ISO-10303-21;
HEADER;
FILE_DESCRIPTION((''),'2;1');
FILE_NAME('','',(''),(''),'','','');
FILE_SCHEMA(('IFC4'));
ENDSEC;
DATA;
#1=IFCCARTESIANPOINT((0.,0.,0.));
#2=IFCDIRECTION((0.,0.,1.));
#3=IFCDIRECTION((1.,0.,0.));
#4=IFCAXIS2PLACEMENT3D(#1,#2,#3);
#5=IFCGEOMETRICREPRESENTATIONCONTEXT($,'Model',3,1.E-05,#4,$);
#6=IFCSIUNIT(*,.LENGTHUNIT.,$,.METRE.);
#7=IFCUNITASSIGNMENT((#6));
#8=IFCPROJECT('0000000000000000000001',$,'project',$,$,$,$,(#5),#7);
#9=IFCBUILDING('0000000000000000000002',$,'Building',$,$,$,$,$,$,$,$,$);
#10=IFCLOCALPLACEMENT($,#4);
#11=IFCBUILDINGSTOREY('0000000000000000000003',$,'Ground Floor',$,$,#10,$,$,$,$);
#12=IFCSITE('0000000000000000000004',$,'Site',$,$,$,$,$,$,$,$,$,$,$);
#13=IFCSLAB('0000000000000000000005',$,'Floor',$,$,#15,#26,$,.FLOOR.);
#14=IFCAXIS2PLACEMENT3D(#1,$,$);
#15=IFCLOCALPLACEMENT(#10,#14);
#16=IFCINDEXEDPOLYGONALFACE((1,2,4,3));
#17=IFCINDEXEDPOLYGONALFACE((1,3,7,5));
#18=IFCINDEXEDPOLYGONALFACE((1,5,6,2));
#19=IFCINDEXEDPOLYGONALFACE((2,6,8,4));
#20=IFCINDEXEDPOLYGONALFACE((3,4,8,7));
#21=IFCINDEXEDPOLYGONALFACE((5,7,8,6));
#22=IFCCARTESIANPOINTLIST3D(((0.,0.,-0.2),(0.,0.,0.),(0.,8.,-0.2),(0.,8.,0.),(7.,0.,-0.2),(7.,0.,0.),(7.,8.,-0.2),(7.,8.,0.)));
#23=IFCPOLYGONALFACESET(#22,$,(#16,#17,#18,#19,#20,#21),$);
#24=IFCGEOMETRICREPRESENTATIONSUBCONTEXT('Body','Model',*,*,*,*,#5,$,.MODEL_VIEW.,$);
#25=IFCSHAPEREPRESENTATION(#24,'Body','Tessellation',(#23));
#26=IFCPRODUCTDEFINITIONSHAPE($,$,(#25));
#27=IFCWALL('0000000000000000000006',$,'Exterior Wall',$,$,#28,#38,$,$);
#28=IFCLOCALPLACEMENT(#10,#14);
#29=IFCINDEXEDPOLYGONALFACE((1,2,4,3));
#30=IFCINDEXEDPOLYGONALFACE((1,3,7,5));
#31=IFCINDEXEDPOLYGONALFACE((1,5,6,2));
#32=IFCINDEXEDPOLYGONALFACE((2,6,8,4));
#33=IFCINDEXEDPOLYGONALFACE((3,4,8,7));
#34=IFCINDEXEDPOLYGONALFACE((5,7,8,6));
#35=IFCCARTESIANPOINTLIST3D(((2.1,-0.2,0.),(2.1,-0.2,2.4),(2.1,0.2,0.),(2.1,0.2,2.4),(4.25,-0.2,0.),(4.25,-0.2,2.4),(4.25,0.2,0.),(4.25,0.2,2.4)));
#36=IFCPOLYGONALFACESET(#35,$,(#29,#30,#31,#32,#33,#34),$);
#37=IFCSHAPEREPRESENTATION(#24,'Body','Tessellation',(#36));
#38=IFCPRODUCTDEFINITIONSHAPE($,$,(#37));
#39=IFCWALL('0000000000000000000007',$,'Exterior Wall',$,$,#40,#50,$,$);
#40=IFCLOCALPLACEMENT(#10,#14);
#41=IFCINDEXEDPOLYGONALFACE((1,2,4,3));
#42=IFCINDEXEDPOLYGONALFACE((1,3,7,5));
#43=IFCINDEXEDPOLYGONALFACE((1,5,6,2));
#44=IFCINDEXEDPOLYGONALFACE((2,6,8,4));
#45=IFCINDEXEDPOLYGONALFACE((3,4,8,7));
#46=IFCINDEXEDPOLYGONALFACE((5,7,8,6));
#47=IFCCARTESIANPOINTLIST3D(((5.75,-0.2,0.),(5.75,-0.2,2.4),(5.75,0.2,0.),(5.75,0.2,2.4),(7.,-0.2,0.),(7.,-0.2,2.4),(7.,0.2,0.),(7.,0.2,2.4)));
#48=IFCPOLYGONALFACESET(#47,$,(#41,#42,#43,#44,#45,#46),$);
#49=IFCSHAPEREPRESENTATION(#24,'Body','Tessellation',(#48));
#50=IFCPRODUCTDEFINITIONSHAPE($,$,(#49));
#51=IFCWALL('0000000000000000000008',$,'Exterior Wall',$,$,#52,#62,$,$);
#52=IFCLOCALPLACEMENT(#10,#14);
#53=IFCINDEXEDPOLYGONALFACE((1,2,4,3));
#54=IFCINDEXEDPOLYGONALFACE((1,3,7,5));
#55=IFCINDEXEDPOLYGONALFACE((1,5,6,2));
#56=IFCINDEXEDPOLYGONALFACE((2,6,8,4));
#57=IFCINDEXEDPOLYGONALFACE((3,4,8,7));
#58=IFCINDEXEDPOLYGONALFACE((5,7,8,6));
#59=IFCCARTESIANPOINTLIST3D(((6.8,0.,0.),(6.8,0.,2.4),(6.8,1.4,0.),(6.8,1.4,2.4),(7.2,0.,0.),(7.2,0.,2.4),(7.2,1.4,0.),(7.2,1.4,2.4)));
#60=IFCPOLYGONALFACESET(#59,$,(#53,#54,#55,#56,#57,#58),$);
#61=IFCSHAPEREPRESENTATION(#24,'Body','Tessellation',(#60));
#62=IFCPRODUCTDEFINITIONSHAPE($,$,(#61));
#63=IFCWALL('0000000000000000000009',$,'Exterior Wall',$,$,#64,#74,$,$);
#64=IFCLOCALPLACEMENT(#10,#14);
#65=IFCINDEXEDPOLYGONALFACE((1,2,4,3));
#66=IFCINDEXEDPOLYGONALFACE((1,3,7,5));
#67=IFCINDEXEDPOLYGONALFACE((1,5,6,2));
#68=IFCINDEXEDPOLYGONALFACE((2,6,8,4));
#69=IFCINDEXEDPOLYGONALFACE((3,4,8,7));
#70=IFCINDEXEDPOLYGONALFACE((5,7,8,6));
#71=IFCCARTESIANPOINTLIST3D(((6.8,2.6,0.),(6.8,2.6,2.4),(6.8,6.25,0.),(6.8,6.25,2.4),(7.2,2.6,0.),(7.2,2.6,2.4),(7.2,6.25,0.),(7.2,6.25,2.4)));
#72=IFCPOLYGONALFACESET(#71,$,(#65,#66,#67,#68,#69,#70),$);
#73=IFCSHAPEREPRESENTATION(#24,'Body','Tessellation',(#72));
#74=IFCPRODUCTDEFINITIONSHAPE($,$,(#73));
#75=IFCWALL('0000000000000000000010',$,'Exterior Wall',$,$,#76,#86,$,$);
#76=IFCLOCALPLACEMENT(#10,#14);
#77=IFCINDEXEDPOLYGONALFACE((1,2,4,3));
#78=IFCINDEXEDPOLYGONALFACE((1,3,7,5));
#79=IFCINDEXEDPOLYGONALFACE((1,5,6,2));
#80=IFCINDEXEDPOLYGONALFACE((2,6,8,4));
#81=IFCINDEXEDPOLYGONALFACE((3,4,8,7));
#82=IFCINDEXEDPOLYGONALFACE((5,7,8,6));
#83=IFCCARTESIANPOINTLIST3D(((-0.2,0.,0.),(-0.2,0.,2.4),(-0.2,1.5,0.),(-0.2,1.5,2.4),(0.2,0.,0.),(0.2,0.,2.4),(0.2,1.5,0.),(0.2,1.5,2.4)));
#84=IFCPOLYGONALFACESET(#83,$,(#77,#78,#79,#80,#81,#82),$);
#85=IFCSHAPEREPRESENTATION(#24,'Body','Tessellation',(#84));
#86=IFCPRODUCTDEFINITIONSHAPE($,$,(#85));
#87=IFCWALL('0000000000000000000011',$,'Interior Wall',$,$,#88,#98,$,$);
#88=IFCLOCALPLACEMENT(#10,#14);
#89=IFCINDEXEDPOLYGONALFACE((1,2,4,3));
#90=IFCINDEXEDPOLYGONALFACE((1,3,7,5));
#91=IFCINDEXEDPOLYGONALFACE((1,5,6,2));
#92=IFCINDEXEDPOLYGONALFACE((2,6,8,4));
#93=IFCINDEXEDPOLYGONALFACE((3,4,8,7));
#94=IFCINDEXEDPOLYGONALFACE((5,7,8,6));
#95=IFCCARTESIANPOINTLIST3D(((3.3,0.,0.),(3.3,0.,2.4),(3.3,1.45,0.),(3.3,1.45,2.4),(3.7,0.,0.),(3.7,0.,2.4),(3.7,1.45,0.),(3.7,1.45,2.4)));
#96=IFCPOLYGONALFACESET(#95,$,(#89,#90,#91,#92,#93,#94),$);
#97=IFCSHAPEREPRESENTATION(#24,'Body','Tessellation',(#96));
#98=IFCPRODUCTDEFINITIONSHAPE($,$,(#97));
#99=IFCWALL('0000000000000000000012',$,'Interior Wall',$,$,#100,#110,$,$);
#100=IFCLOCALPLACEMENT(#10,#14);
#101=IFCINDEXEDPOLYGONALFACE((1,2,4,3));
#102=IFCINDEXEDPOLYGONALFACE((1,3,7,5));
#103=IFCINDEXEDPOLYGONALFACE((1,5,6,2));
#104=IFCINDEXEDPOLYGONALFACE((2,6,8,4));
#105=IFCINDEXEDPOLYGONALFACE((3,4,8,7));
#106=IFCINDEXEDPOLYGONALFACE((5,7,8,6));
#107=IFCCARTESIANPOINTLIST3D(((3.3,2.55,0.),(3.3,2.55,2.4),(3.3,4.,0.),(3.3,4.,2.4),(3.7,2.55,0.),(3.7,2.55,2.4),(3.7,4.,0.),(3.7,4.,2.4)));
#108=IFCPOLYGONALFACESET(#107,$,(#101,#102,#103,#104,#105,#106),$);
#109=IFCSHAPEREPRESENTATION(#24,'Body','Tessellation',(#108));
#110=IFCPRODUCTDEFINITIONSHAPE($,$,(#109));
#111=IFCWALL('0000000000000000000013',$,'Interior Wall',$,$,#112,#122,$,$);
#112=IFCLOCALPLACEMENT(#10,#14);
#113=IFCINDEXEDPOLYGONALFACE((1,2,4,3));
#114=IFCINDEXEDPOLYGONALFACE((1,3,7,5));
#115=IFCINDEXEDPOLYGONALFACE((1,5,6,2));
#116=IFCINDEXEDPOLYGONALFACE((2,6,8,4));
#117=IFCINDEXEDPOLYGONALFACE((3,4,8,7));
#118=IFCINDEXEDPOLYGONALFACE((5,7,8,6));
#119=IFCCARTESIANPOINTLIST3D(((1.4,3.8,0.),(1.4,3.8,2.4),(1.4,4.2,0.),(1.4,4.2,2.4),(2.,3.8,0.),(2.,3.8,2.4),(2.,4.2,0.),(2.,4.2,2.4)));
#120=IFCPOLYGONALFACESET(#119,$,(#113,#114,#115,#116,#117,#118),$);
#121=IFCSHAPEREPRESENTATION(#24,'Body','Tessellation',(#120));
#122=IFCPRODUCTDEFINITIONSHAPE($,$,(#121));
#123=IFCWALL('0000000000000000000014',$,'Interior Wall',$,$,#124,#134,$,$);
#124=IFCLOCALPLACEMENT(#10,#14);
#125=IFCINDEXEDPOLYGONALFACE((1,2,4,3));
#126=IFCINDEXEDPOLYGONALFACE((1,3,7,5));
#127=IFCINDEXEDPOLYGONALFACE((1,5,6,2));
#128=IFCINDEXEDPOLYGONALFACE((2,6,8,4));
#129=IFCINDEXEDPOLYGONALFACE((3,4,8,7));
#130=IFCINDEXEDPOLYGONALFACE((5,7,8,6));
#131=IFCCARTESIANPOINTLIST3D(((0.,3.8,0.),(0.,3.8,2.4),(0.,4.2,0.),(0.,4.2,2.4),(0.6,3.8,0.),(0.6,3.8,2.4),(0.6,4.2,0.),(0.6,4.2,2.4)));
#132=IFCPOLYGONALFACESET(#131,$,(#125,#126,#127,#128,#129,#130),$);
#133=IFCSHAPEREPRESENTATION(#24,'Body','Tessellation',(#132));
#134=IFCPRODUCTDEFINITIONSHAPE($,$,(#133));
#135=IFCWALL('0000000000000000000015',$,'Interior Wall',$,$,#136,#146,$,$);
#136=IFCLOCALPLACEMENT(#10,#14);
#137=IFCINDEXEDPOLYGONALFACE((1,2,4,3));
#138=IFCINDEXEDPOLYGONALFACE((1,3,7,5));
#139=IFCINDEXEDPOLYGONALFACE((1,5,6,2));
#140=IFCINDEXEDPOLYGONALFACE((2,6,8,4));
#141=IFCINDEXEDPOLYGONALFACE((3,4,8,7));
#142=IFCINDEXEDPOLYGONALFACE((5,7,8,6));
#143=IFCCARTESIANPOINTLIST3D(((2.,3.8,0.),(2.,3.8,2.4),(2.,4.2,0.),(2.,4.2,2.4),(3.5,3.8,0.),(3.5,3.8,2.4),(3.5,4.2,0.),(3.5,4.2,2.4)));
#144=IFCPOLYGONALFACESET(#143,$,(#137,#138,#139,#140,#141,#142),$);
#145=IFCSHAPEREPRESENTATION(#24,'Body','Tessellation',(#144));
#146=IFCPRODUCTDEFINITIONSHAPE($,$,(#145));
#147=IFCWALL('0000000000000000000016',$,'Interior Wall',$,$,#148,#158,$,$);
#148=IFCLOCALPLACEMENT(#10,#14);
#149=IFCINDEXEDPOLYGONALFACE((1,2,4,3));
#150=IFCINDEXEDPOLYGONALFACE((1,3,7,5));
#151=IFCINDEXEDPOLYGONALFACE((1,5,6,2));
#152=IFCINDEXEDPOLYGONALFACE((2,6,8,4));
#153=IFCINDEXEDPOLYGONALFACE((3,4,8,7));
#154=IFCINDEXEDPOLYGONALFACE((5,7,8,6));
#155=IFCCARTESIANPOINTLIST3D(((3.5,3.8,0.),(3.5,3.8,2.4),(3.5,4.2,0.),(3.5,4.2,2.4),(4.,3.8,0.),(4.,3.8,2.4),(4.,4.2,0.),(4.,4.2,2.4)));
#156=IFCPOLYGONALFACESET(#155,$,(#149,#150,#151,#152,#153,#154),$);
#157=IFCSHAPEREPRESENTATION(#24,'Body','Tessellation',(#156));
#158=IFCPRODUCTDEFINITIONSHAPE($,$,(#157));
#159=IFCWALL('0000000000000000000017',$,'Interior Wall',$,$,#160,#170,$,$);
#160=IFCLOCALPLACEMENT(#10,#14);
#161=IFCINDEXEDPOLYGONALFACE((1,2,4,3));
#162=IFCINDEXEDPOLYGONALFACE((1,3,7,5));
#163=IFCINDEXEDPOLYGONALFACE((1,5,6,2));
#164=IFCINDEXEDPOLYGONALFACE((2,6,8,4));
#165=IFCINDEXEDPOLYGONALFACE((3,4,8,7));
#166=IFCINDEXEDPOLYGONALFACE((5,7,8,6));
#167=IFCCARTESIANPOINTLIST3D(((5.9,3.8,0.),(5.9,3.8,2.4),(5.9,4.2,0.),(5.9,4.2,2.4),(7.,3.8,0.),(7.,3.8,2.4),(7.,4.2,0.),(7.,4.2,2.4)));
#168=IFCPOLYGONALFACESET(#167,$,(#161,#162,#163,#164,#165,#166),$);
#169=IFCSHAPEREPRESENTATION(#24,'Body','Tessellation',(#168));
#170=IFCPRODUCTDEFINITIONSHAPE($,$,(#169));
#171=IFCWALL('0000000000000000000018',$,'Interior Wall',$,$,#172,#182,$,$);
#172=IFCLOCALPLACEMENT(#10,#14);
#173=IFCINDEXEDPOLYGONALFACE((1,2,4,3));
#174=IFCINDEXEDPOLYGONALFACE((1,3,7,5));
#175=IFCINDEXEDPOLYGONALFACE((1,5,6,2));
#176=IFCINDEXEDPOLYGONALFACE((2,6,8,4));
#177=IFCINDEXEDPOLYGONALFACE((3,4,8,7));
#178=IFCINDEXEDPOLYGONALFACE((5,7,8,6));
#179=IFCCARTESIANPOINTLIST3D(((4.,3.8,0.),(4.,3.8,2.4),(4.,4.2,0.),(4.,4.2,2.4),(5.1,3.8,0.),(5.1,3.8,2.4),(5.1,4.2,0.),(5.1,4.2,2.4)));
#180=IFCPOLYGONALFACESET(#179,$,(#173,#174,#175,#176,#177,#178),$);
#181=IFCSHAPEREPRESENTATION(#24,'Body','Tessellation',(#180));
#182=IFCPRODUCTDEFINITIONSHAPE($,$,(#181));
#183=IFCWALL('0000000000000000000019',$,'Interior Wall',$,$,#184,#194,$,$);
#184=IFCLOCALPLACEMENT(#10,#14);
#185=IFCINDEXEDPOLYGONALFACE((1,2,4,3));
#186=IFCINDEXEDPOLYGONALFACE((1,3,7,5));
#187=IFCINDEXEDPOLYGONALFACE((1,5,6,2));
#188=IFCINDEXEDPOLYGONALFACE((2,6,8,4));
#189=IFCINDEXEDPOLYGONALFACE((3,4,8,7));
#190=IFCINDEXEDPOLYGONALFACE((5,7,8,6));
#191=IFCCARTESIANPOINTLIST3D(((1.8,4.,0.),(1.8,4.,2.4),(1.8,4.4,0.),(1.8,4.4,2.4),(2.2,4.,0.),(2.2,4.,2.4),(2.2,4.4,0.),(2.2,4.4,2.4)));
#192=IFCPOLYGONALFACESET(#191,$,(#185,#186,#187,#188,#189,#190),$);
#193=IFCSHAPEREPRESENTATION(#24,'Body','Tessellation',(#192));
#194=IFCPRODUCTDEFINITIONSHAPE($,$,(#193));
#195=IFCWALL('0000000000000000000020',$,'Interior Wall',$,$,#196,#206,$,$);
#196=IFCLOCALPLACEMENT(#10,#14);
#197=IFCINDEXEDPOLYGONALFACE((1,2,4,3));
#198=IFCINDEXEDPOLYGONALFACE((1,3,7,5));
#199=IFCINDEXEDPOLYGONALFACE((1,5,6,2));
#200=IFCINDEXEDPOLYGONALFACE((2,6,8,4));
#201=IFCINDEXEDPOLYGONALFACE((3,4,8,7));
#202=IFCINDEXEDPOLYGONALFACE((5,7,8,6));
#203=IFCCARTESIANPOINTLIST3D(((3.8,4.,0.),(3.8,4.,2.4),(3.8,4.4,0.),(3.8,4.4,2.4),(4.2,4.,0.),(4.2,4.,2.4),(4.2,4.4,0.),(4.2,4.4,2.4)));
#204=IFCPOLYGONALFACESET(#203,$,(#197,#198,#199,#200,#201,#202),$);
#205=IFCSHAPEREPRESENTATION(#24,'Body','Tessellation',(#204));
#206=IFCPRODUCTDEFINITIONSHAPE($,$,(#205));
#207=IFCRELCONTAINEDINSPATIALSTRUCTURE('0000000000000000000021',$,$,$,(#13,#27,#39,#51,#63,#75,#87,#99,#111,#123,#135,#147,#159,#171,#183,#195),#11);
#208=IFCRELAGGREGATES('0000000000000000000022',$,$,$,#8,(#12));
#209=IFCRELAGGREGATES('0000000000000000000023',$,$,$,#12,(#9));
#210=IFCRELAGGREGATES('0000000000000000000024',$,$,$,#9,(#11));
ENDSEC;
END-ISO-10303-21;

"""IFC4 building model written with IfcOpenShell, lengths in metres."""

from ifc_helpers import new_model, si_unit, frame, origin_with_axes, place, context, subcontext, project, spatial, indexed_curve, outline, extrude, element, save


model = new_model("IFC4")

# Units and contexts
model_context = context("Model", 3, precision=1e-05, world=origin_with_axes())
body_context = subcontext(model_context, "Body", "Model", "MODEL_VIEW")
ifc_project = project(units=[si_unit("LENGTHUNIT", "METRE")], contexts=[model_context])

# Site, building, storey
site = spatial("IfcSite", under=ifc_project, Name="Site")
building = spatial("IfcBuilding", under=site, Name="Building")
storey_placement = place(None, origin_with_axes())
storey = spatial("IfcBuildingStorey", under=building, at=storey_placement, Name="Ground Floor")

# Slab
slab_placement = place(storey_placement, frame((0.0, 0.0, -0.2), z_axis=(0.0, 0.0, 1.0), x_axis=(1.0, 0.0, 0.0)))
element("IfcSlab", 1, at=slab_placement, inside=storey, Name="Floor", PredefinedType="FLOOR", context=body_context, shape_type="SweptSolid", body=[
    extrude(outline(indexed_curve([(0.0, 0.0), (7.0, 0.0), (7.0, 8.0), (0.0, 8.0)])), None, (0.0, 0.0, 1.0), 0.2),
])

# Walls
wall_1_placement = place(storey_placement, frame((2.1, 0.0, 0.0), z_axis=(0.0, 0.0, 1.0), x_axis=(1.0, 0.0, 0.0)))
element("IfcWall", 2, at=wall_1_placement, inside=storey, Name="Exterior Wall", context=body_context, shape_type="SweptSolid", body=[
    extrude(outline(indexed_curve([(0.0, 0.0), (0.0, 0.4), (2.15, 0.4), (2.15, 0.0), (0.0, 0.0)], self_intersect=False)), frame((0.0, -0.2, 0.0), z_axis=(0.0, 0.0, 1.0), x_axis=(1.0, 0.0, 0.0)), (0.0, 0.0, 1.0), 2.4),
])
wall_2_placement = place(storey_placement, frame((5.75, 0.0, 0.0), z_axis=(0.0, 0.0, 1.0), x_axis=(1.0, 0.0, 0.0)))
element("IfcWall", 3, at=wall_2_placement, inside=storey, Name="Exterior Wall", context=body_context, shape_type="SweptSolid", body=[
    extrude(outline(indexed_curve([(0.0, 0.0), (0.0, 0.4), (1.25, 0.4), (1.25, 0.0), (0.0, 0.0)], self_intersect=False)), frame((0.0, -0.2, 0.0), z_axis=(0.0, 0.0, 1.0), x_axis=(1.0, 0.0, 0.0)), (0.0, 0.0, 1.0), 2.4),
])
wall_3_placement = place(storey_placement, frame((7.0, 0.0, 0.0), z_axis=(0.0, 0.0, 1.0), x_axis=(0.0, 1.0, 0.0)))
element("IfcWall", 4, at=wall_3_placement, inside=storey, Name="Exterior Wall", context=body_context, shape_type="SweptSolid", body=[
    extrude(outline(indexed_curve([(0.0, 0.0), (0.0, 0.4), (1.4, 0.4), (1.4, 0.0), (0.0, 0.0)], self_intersect=False)), frame((0.0, -0.2, 0.0), z_axis=(0.0, 0.0, 1.0), x_axis=(1.0, 0.0, 0.0)), (0.0, 0.0, 1.0), 2.4),
])
wall_4_placement = place(storey_placement, frame((7.0, 2.6, 0.0), z_axis=(0.0, 0.0, 1.0), x_axis=(0.0, 1.0, 0.0)))
element("IfcWall", 5, at=wall_4_placement, inside=storey, Name="Exterior Wall", context=body_context, shape_type="SweptSolid", body=[
    extrude(outline(indexed_curve([(0.0, 0.0), (0.0, 0.4), (3.65, 0.4), (3.65, 0.0), (0.0, 0.0)], self_intersect=False)), frame((0.0, -0.2, 0.0), z_axis=(0.0, 0.0, 1.0), x_axis=(1.0, 0.0, 0.0)), (0.0, 0.0, 1.0), 2.4),
])
wall_5_placement = place(storey_placement, frame((0.0, 1.5, 0.0), z_axis=(0.0, 0.0, 1.0), x_axis=(0.0, -1.0, 0.0)))
element("IfcWall", 6, at=wall_5_placement, inside=storey, Name="Exterior Wall", context=body_context, shape_type="SweptSolid", body=[
    extrude(outline(indexed_curve([(0.0, 0.0), (0.0, 0.4), (1.5, 0.4), (1.5, 0.0), (0.0, 0.0)], self_intersect=False)), frame((0.0, -0.2, 0.0), z_axis=(0.0, 0.0, 1.0), x_axis=(1.0, 0.0, 0.0)), (0.0, 0.0, 1.0), 2.4),
])
wall_6_placement = place(storey_placement, frame((3.5, 0.0, 0.0), z_axis=(0.0, 0.0, 1.0), x_axis=(0.0, 1.0, 0.0)))
element("IfcWall", 7, at=wall_6_placement, inside=storey, Name="Interior Wall", context=body_context, shape_type="SweptSolid", body=[
    extrude(outline(indexed_curve([(0.0, 0.0), (0.0, 0.4), (1.45, 0.4), (1.45, 0.0), (0.0, 0.0)], self_intersect=False)), frame((0.0, -0.2, 0.0), z_axis=(0.0, 0.0, 1.0), x_axis=(1.0, 0.0, 0.0)), (0.0, 0.0, 1.0), 2.4),
])
wall_7_placement = place(storey_placement, frame((3.5, 2.55, 0.0), z_axis=(0.0, 0.0, 1.0), x_axis=(0.0, 1.0, 0.0)))
element("IfcWall", 8, at=wall_7_placement, inside=storey, Name="Interior Wall", context=body_context, shape_type="SweptSolid", body=[
    extrude(outline(indexed_curve([(0.0, 0.0), (0.0, 0.4), (1.45, 0.4), (1.45, 0.0), (0.0, 0.0)], self_intersect=False)), frame((0.0, -0.2, 0.0), z_axis=(0.0, 0.0, 1.0), x_axis=(1.0, 0.0, 0.0)), (0.0, 0.0, 1.0), 2.4),
])
for number, where, z_axis, x_axis, name in (
    (9, (2.0, 4.0, 0.0), (0.0, 0.0, 1.0), (-1.0, 0.0, 0.0), "Interior Wall"),
    (10, (0.6, 4.0, 0.0), (0.0, 0.0, 1.0), (-1.0, 0.0, 0.0), "Interior Wall"),
):
    element("IfcWall", number, at=place(storey_placement, frame(where, z_axis=z_axis, x_axis=x_axis)), inside=storey, Name=name, context=body_context, shape_type="SweptSolid", body=[
        extrude(outline(indexed_curve([(0.0, 0.0), (0.0, 0.4), (0.6, 0.4), (0.6, 0.0), (0.0, 0.0)], self_intersect=False)), frame((0.0, -0.2, 0.0), z_axis=(0.0, 0.0, 1.0), x_axis=(1.0, 0.0, 0.0)), (0.0, 0.0, 1.0), 2.4),
    ])
wall_8_placement = place(storey_placement, frame((3.5, 4.0, 0.0), z_axis=(0.0, 0.0, 1.0), x_axis=(-1.0, 0.0, 0.0)))
element("IfcWall", 11, at=wall_8_placement, inside=storey, Name="Interior Wall", context=body_context, shape_type="SweptSolid", body=[
    extrude(outline(indexed_curve([(0.0, 0.0), (0.0, 0.4), (1.5, 0.4), (1.5, 0.0), (0.0, 0.0)], self_intersect=False)), frame((0.0, -0.2, 0.0), z_axis=(0.0, 0.0, 1.0), x_axis=(1.0, 0.0, 0.0)), (0.0, 0.0, 1.0), 2.4),
])
wall_9_placement = place(storey_placement, frame((4.0, 4.0, 0.0), z_axis=(0.0, 0.0, 1.0), x_axis=(-1.0, 0.0, 0.0)))
element("IfcWall", 12, at=wall_9_placement, inside=storey, Name="Interior Wall", context=body_context, shape_type="SweptSolid", body=[
    extrude(outline(indexed_curve([(0.0, 0.0), (0.0, 0.4), (0.5, 0.4), (0.5, 0.0), (0.0, 0.0)], self_intersect=False)), frame((0.0, -0.2, 0.0), z_axis=(0.0, 0.0, 1.0), x_axis=(1.0, 0.0, 0.0)), (0.0, 0.0, 1.0), 2.4),
])
for number, where, z_axis, x_axis, name in (
    (13, (7.0, 4.0, 0.0), (0.0, 0.0, 1.0), (-1.0, 0.0, 0.0), "Interior Wall"),
    (14, (5.1, 4.0, 0.0), (0.0, 0.0, 1.0), (-1.0, 0.0, 0.0), "Interior Wall"),
):
    element("IfcWall", number, at=place(storey_placement, frame(where, z_axis=z_axis, x_axis=x_axis)), inside=storey, Name=name, context=body_context, shape_type="SweptSolid", body=[
        extrude(outline(indexed_curve([(0.0, 0.0), (0.0, 0.4), (1.1, 0.4), (1.1, 0.0), (0.0, 0.0)], self_intersect=False)), frame((0.0, -0.2, 0.0), z_axis=(0.0, 0.0, 1.0), x_axis=(1.0, 0.0, 0.0)), (0.0, 0.0, 1.0), 2.4),
    ])
for number, where, z_axis, x_axis, name in (
    (15, (2.0, 4.0, 0.0), (0.0, 0.0, 1.0), (0.0, 1.0, 0.0), "Interior Wall"),
    (16, (4.0, 4.0, 0.0), (0.0, 0.0, 1.0), (0.0, 1.0, 0.0), "Interior Wall"),
):
    element("IfcWall", number, at=place(storey_placement, frame(where, z_axis=z_axis, x_axis=x_axis)), inside=storey, Name=name, context=body_context, shape_type="SweptSolid", body=[
        extrude(outline(indexed_curve([(0.0, 0.0), (0.0, 0.4), (0.4, 0.4), (0.4, 0.0), (0.0, 0.0)], self_intersect=False)), frame((0.0, -0.2, 0.0), z_axis=(0.0, 0.0, 1.0), x_axis=(1.0, 0.0, 0.0)), (0.0, 0.0, 1.0), 2.4),
    ])

save(model, "model.ifc")
